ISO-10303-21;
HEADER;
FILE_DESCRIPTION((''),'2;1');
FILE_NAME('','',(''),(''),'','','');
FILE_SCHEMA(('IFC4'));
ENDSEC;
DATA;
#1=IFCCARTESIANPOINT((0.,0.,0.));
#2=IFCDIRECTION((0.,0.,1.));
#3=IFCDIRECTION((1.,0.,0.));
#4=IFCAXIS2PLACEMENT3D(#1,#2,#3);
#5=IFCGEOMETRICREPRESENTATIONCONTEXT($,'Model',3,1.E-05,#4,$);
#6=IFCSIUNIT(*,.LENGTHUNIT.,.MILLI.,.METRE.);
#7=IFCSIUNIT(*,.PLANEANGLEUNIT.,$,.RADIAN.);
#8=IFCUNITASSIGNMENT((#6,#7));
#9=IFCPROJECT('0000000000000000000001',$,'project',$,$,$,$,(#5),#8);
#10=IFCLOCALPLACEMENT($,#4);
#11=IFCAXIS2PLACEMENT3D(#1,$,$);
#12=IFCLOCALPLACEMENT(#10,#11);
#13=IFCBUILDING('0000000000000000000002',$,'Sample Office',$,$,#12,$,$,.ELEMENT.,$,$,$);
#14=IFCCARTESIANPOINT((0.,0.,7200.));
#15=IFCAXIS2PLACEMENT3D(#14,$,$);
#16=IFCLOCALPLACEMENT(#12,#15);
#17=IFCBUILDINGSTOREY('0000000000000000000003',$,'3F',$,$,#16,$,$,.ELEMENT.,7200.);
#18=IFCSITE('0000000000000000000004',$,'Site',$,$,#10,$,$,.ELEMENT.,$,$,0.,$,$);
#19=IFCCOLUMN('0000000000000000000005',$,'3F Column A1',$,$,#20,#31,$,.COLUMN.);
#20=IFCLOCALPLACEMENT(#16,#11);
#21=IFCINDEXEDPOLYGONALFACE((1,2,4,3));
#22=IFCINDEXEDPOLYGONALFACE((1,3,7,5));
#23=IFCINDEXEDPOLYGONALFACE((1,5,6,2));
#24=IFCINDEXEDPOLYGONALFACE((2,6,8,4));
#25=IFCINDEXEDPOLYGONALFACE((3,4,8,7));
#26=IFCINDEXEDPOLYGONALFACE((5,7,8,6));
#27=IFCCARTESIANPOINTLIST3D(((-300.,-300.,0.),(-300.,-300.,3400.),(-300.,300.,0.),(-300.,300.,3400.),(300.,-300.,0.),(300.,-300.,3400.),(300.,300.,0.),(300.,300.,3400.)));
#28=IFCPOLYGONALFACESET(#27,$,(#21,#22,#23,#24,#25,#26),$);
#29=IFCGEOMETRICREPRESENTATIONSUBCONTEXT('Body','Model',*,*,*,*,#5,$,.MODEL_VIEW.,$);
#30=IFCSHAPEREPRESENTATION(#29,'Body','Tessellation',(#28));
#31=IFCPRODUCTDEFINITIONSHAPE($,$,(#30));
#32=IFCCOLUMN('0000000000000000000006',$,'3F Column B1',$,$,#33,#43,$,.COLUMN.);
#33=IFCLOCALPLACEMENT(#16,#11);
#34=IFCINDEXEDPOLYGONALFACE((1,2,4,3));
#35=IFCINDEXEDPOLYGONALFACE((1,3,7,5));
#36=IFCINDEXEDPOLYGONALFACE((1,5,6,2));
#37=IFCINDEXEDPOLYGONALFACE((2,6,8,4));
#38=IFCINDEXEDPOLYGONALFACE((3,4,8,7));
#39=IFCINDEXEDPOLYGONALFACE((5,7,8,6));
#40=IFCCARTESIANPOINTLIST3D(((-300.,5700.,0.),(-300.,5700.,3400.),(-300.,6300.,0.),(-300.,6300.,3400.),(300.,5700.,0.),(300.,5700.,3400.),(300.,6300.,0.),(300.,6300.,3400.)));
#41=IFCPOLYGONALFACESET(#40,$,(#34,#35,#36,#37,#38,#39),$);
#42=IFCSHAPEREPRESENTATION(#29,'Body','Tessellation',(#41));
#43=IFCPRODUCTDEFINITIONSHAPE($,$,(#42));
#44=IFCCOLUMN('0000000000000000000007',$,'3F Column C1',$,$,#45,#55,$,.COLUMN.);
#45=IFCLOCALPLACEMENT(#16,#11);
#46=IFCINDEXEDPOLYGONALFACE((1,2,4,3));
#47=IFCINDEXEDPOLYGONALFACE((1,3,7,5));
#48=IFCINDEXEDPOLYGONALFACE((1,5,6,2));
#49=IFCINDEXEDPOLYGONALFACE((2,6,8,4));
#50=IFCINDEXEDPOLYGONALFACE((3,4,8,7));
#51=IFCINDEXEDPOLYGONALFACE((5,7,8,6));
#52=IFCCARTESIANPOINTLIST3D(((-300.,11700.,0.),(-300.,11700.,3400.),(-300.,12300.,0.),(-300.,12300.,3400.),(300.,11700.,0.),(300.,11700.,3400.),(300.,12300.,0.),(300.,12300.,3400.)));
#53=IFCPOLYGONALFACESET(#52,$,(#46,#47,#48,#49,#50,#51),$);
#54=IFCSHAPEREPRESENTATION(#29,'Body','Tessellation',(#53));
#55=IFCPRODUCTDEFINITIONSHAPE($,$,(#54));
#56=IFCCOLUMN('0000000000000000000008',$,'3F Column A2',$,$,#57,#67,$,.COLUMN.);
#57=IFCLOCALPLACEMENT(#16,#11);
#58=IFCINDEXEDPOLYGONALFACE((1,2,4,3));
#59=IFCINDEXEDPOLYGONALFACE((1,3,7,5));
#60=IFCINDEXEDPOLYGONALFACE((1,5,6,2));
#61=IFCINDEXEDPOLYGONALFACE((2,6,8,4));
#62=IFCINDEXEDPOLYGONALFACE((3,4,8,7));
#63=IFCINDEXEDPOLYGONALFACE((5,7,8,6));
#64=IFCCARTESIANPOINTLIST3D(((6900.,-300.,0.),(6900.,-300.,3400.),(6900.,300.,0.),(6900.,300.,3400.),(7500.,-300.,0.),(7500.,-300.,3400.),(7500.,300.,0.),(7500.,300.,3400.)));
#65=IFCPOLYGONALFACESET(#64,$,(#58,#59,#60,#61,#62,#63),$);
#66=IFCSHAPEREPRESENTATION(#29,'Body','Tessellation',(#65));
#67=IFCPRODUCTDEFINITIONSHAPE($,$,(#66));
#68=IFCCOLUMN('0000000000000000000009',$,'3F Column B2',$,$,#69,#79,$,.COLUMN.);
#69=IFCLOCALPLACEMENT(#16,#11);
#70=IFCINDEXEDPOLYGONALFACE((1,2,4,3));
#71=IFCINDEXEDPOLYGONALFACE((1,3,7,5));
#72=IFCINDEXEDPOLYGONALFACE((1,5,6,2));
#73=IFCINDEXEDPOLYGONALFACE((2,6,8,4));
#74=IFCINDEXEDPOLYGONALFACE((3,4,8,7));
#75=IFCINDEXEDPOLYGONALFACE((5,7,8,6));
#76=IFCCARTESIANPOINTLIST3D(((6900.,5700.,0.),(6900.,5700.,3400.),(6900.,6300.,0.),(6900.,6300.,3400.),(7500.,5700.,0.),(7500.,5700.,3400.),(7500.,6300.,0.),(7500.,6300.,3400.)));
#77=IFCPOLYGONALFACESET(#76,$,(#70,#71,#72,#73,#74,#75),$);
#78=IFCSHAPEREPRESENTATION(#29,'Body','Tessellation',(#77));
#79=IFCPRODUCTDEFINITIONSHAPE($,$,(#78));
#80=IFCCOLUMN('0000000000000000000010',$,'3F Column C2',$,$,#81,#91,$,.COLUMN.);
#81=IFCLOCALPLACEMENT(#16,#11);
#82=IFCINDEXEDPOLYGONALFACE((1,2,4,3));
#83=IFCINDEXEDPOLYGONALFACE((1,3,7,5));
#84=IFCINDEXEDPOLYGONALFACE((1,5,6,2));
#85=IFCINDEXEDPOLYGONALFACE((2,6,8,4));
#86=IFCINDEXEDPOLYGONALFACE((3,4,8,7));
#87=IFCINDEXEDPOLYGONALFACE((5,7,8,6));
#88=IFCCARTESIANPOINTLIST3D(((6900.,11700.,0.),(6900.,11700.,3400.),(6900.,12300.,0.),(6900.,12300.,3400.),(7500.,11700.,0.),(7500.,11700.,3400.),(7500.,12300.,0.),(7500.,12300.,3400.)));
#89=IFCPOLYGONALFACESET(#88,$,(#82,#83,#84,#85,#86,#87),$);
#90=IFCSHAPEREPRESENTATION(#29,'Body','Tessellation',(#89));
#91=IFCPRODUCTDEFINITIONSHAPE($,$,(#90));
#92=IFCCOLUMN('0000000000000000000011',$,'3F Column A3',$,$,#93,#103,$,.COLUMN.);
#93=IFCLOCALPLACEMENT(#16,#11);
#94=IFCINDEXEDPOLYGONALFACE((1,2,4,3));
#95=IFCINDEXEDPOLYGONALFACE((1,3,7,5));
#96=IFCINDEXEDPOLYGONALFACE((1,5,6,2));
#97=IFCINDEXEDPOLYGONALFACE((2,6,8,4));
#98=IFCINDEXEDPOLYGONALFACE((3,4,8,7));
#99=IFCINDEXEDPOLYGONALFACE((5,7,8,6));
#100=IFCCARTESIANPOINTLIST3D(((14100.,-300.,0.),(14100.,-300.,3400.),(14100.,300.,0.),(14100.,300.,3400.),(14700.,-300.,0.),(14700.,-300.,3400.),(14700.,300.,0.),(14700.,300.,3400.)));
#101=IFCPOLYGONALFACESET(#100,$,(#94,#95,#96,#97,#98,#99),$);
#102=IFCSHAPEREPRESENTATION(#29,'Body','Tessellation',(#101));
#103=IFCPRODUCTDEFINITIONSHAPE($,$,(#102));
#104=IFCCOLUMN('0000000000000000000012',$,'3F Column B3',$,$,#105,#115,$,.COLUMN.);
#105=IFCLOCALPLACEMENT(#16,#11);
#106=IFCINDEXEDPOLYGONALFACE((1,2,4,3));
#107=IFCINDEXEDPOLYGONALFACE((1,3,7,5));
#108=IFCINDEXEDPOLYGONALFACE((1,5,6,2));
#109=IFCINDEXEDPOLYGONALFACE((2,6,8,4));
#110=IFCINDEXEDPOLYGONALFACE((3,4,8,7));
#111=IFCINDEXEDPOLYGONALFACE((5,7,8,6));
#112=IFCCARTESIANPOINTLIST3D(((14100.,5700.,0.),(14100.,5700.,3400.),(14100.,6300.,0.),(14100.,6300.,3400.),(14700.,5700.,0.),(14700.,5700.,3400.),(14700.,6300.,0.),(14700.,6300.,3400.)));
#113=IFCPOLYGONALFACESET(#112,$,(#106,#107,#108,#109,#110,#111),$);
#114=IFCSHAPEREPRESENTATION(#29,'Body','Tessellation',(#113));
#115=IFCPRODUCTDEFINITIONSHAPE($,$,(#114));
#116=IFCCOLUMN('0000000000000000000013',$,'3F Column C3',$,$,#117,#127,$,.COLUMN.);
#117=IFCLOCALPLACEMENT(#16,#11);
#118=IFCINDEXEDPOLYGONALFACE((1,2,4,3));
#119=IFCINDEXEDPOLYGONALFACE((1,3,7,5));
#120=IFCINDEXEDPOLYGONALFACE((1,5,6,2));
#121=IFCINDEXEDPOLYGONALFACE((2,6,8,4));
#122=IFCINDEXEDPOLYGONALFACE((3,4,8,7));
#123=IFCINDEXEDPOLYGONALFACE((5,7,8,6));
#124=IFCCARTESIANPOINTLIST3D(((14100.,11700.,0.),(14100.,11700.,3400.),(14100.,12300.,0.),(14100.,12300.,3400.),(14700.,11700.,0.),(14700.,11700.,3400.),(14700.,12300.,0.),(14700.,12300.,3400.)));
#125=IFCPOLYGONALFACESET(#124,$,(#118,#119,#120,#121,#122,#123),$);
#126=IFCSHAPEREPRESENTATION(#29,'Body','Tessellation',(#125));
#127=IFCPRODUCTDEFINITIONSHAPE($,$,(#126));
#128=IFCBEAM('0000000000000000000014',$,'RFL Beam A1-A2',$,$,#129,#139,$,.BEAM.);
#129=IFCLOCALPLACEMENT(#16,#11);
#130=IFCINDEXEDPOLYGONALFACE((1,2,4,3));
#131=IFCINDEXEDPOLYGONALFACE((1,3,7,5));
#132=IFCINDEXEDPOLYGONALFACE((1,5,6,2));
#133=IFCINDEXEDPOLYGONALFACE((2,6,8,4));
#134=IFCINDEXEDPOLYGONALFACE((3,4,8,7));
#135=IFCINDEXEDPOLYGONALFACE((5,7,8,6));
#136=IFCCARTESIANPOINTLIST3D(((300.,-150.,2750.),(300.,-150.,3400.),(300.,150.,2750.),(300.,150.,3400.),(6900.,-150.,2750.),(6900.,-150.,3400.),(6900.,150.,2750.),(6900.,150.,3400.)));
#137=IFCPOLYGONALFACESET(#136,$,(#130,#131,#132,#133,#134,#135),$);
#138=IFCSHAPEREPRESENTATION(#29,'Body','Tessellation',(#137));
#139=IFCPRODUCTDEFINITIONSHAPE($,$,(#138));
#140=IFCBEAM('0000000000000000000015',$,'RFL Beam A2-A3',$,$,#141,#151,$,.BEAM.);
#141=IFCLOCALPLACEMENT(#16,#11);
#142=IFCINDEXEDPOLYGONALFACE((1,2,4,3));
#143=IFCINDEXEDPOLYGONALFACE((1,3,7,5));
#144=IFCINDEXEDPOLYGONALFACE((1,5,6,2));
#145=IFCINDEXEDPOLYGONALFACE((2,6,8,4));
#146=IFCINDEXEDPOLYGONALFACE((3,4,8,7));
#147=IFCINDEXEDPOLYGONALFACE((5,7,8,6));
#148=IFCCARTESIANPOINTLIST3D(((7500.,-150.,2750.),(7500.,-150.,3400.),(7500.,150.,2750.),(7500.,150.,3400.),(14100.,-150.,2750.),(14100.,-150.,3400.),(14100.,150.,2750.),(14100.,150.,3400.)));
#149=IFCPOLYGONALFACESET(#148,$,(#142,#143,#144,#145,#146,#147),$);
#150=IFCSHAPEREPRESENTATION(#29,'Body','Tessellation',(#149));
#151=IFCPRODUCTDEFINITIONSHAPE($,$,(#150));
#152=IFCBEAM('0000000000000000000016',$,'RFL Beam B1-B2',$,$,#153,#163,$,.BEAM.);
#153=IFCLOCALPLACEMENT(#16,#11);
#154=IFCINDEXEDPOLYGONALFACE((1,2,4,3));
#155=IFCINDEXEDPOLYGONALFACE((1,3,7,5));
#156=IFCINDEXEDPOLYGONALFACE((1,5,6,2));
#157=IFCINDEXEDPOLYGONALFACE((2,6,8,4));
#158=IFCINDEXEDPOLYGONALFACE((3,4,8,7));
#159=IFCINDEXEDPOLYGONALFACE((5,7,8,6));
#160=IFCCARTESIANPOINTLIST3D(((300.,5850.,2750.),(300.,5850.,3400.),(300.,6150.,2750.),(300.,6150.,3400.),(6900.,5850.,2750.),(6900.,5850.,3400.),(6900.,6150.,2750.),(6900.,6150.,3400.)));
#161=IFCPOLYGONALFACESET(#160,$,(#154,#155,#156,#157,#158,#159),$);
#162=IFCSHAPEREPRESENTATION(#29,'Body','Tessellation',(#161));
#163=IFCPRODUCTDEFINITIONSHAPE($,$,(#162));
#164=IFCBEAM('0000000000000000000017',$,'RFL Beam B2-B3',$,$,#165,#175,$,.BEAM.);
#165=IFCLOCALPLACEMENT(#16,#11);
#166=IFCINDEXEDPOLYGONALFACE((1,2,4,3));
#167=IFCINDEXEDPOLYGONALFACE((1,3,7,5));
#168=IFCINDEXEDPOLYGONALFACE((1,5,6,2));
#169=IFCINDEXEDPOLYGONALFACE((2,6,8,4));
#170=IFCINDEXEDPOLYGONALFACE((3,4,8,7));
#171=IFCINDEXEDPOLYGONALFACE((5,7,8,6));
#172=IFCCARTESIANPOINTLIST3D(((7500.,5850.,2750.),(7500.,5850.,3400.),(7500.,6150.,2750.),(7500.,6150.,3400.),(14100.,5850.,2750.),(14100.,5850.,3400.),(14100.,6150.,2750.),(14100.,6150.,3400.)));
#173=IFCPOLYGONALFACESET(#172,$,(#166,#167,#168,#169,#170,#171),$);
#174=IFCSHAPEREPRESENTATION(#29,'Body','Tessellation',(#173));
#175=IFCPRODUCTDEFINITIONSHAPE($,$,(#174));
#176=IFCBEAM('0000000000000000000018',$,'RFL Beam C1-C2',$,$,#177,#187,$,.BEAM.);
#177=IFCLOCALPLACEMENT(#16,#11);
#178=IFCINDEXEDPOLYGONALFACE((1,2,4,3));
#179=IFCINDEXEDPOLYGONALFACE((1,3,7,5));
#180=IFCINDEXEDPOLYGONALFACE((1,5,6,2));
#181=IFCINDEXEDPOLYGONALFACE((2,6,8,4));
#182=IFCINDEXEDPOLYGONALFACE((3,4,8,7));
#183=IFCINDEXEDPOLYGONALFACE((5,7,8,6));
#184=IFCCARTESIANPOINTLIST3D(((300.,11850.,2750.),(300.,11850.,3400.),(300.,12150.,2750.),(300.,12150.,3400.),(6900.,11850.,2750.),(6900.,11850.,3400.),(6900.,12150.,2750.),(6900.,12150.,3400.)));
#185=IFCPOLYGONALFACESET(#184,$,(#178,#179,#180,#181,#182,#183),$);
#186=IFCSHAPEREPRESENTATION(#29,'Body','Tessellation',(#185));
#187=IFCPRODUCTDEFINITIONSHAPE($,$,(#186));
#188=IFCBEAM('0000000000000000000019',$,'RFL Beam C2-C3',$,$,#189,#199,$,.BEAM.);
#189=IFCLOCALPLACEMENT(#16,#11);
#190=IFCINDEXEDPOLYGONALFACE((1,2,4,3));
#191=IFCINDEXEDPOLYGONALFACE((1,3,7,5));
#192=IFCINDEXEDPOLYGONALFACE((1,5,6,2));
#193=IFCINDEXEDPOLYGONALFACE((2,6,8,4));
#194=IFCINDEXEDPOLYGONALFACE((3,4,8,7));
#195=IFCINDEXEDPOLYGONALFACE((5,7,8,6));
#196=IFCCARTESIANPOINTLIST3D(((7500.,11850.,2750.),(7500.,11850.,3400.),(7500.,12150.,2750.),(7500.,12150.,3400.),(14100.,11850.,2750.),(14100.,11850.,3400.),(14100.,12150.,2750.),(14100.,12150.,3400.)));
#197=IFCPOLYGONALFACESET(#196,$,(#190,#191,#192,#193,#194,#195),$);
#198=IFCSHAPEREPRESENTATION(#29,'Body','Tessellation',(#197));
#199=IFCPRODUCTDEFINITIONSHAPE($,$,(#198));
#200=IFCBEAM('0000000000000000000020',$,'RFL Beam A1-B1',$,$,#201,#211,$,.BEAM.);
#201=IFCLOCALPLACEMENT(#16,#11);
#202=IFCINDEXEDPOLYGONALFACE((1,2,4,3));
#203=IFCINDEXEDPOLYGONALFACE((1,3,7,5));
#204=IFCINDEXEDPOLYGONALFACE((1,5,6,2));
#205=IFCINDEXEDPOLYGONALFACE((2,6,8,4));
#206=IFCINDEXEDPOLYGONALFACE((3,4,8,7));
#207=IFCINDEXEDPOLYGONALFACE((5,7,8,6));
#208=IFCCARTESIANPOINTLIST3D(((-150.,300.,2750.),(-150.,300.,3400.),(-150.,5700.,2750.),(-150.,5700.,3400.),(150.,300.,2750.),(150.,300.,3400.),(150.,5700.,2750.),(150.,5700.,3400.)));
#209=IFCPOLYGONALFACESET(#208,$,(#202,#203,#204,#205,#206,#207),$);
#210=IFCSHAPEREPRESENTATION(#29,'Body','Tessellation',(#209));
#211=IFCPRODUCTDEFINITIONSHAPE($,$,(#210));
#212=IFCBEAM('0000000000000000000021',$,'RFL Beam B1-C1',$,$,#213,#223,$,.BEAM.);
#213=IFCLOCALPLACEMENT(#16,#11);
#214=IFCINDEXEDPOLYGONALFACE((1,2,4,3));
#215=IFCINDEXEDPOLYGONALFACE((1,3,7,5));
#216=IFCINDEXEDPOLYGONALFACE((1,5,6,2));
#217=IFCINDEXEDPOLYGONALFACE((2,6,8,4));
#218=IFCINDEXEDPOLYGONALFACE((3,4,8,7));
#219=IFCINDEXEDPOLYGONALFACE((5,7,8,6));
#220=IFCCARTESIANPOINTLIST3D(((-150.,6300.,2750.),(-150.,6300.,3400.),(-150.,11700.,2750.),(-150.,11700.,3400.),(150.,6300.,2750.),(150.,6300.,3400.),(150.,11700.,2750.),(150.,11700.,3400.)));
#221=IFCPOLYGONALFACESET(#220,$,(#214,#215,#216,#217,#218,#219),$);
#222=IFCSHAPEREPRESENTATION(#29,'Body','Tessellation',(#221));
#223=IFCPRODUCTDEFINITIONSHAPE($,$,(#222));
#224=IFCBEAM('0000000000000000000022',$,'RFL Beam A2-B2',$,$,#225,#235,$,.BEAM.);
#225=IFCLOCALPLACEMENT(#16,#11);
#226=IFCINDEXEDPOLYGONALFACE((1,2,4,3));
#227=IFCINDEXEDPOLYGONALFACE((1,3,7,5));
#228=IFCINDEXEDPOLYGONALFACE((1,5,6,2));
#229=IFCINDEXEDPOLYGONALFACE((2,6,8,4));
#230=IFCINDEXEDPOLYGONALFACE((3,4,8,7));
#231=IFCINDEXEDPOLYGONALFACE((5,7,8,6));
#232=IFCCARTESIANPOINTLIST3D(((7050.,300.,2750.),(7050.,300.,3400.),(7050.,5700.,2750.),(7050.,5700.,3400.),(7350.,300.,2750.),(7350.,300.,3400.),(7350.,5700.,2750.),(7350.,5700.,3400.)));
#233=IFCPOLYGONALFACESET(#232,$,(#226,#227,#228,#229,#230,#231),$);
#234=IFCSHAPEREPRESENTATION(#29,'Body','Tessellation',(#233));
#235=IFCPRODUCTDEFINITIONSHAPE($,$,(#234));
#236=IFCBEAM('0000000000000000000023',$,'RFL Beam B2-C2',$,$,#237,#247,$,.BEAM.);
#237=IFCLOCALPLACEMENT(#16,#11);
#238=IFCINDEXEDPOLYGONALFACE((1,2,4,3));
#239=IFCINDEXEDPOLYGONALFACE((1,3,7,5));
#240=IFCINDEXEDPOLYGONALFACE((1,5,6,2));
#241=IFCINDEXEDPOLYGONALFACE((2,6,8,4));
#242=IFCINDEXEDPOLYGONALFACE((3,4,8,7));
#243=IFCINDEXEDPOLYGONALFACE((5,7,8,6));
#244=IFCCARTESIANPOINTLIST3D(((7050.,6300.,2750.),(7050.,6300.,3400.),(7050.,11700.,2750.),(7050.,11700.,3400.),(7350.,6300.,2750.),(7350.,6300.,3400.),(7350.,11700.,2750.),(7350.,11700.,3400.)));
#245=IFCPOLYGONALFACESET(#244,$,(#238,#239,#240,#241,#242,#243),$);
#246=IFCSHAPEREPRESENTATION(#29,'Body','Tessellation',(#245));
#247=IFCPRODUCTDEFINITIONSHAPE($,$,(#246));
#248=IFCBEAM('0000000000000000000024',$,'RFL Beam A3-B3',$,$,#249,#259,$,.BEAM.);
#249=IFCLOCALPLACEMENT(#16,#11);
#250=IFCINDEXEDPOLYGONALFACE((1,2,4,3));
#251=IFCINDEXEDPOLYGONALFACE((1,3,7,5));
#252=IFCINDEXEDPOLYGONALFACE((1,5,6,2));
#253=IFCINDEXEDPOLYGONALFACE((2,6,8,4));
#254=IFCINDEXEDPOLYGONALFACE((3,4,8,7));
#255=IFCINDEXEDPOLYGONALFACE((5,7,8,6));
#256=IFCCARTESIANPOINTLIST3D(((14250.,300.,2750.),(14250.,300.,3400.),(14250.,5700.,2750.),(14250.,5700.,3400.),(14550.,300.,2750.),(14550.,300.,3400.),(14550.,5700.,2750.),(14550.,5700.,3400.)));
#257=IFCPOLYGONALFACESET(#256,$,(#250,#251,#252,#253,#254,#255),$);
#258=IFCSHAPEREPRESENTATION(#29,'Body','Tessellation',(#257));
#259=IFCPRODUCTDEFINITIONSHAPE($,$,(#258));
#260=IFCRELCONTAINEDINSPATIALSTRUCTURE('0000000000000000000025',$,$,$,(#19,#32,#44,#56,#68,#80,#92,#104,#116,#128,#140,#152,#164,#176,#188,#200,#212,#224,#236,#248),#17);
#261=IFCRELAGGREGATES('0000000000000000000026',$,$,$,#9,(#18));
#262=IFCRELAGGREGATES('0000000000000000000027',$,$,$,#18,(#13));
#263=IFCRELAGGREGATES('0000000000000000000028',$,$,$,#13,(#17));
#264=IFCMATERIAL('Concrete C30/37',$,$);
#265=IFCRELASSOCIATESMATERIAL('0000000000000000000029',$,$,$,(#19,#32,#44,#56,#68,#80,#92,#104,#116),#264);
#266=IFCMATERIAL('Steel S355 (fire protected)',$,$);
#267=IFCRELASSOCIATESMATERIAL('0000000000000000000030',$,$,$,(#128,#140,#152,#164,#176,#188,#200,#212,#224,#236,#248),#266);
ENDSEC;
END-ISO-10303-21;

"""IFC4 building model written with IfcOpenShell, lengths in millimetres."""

from ifc_helpers import new_model, si_unit, frame, origin, origin_with_axes, origin_2d, place, context, subcontext, project, spatial, rectangle, extrude, material, element, save


model = new_model("IFC4")

# Units and contexts
model_context = context("Model", 3, precision=1e-05, world=origin_with_axes())
body_context = subcontext(model_context, "Body", "Model", "MODEL_VIEW")
ifc_project = project(units=[si_unit("LENGTHUNIT", "METRE", prefix="MILLI"), si_unit("PLANEANGLEUNIT", "RADIAN")], contexts=[model_context])

# Site, building, storey
site_placement = place(None, origin_with_axes())
site = spatial("IfcSite", under=ifc_project, at=site_placement, Name="Site", CompositionType="ELEMENT", RefElevation=0.0)
building_placement = place(site_placement, origin())
building = spatial("IfcBuilding", under=site, at=building_placement, Name="Sample Office", CompositionType="ELEMENT")
storey_placement = place(building_placement, frame((0.0, 0.0, 7200.0)))
storey = spatial("IfcBuildingStorey", under=building, at=storey_placement, Name="3F", CompositionType="ELEMENT", Elevation=7200.0)

# Columns
ifc_material_1 = material(Name="Concrete C30/37")
for number, where, name in (
    (1, (0.0, 0.0, 0.0), "3F Column A1"),
    (2, (0.0, 6000.0, 0.0), "3F Column B1"),
    (3, (0.0, 12000.0, 0.0), "3F Column C1"),
    (4, (7200.0, 0.0, 0.0), "3F Column A2"),
    (5, (7200.0, 6000.0, 0.0), "3F Column B2"),
    (6, (7200.0, 12000.0, 0.0), "3F Column C2"),
    (7, (14400.0, 0.0, 0.0), "3F Column A3"),
    (8, (14400.0, 6000.0, 0.0), "3F Column B3"),
    (9, (14400.0, 12000.0, 0.0), "3F Column C3"),
):
    element("IfcColumn", number, at=place(storey_placement, frame(where)), inside=storey, material=ifc_material_1, Name=name, PredefinedType="COLUMN", context=body_context, shape_type="SweptSolid", body=[
        extrude(rectangle(XDim=600.0, YDim=600.0, at=origin_2d()), origin(), (0.0, 0.0, 1.0), 3400.0),
    ])

# Beams
ifc_material_2 = material(Name="Steel S355 (fire protected)")
for number, where, name in (
    (10, (3600.0, 0.0, 2750.0), "RFL Beam A1-A2"),
    (11, (10800.0, 0.0, 2750.0), "RFL Beam A2-A3"),
    (12, (3600.0, 6000.0, 2750.0), "RFL Beam B1-B2"),
    (13, (10800.0, 6000.0, 2750.0), "RFL Beam B2-B3"),
    (14, (3600.0, 12000.0, 2750.0), "RFL Beam C1-C2"),
    (15, (10800.0, 12000.0, 2750.0), "RFL Beam C2-C3"),
):
    element("IfcBeam", number, at=place(storey_placement, frame(where)), inside=storey, material=ifc_material_2, Name=name, PredefinedType="BEAM", context=body_context, shape_type="SweptSolid", body=[
        extrude(rectangle(XDim=6600.0, YDim=300.0, at=origin_2d()), origin(), (0.0, 0.0, 1.0), 650.0),
    ])
for number, where, name in (
    (16, (0.0, 3000.0, 2750.0), "RFL Beam A1-B1"),
    (17, (0.0, 9000.0, 2750.0), "RFL Beam B1-C1"),
    (18, (7200.0, 3000.0, 2750.0), "RFL Beam A2-B2"),
    (19, (7200.0, 9000.0, 2750.0), "RFL Beam B2-C2"),
    (20, (14400.0, 3000.0, 2750.0), "RFL Beam A3-B3"),
):
    element("IfcBeam", number, at=place(storey_placement, frame(where)), inside=storey, material=ifc_material_2, Name=name, PredefinedType="BEAM", context=body_context, shape_type="SweptSolid", body=[
        extrude(rectangle(XDim=300.0, YDim=5400.0, at=origin_2d()), origin(), (0.0, 0.0, 1.0), 650.0),
    ])

save(model, "model.ifc")
